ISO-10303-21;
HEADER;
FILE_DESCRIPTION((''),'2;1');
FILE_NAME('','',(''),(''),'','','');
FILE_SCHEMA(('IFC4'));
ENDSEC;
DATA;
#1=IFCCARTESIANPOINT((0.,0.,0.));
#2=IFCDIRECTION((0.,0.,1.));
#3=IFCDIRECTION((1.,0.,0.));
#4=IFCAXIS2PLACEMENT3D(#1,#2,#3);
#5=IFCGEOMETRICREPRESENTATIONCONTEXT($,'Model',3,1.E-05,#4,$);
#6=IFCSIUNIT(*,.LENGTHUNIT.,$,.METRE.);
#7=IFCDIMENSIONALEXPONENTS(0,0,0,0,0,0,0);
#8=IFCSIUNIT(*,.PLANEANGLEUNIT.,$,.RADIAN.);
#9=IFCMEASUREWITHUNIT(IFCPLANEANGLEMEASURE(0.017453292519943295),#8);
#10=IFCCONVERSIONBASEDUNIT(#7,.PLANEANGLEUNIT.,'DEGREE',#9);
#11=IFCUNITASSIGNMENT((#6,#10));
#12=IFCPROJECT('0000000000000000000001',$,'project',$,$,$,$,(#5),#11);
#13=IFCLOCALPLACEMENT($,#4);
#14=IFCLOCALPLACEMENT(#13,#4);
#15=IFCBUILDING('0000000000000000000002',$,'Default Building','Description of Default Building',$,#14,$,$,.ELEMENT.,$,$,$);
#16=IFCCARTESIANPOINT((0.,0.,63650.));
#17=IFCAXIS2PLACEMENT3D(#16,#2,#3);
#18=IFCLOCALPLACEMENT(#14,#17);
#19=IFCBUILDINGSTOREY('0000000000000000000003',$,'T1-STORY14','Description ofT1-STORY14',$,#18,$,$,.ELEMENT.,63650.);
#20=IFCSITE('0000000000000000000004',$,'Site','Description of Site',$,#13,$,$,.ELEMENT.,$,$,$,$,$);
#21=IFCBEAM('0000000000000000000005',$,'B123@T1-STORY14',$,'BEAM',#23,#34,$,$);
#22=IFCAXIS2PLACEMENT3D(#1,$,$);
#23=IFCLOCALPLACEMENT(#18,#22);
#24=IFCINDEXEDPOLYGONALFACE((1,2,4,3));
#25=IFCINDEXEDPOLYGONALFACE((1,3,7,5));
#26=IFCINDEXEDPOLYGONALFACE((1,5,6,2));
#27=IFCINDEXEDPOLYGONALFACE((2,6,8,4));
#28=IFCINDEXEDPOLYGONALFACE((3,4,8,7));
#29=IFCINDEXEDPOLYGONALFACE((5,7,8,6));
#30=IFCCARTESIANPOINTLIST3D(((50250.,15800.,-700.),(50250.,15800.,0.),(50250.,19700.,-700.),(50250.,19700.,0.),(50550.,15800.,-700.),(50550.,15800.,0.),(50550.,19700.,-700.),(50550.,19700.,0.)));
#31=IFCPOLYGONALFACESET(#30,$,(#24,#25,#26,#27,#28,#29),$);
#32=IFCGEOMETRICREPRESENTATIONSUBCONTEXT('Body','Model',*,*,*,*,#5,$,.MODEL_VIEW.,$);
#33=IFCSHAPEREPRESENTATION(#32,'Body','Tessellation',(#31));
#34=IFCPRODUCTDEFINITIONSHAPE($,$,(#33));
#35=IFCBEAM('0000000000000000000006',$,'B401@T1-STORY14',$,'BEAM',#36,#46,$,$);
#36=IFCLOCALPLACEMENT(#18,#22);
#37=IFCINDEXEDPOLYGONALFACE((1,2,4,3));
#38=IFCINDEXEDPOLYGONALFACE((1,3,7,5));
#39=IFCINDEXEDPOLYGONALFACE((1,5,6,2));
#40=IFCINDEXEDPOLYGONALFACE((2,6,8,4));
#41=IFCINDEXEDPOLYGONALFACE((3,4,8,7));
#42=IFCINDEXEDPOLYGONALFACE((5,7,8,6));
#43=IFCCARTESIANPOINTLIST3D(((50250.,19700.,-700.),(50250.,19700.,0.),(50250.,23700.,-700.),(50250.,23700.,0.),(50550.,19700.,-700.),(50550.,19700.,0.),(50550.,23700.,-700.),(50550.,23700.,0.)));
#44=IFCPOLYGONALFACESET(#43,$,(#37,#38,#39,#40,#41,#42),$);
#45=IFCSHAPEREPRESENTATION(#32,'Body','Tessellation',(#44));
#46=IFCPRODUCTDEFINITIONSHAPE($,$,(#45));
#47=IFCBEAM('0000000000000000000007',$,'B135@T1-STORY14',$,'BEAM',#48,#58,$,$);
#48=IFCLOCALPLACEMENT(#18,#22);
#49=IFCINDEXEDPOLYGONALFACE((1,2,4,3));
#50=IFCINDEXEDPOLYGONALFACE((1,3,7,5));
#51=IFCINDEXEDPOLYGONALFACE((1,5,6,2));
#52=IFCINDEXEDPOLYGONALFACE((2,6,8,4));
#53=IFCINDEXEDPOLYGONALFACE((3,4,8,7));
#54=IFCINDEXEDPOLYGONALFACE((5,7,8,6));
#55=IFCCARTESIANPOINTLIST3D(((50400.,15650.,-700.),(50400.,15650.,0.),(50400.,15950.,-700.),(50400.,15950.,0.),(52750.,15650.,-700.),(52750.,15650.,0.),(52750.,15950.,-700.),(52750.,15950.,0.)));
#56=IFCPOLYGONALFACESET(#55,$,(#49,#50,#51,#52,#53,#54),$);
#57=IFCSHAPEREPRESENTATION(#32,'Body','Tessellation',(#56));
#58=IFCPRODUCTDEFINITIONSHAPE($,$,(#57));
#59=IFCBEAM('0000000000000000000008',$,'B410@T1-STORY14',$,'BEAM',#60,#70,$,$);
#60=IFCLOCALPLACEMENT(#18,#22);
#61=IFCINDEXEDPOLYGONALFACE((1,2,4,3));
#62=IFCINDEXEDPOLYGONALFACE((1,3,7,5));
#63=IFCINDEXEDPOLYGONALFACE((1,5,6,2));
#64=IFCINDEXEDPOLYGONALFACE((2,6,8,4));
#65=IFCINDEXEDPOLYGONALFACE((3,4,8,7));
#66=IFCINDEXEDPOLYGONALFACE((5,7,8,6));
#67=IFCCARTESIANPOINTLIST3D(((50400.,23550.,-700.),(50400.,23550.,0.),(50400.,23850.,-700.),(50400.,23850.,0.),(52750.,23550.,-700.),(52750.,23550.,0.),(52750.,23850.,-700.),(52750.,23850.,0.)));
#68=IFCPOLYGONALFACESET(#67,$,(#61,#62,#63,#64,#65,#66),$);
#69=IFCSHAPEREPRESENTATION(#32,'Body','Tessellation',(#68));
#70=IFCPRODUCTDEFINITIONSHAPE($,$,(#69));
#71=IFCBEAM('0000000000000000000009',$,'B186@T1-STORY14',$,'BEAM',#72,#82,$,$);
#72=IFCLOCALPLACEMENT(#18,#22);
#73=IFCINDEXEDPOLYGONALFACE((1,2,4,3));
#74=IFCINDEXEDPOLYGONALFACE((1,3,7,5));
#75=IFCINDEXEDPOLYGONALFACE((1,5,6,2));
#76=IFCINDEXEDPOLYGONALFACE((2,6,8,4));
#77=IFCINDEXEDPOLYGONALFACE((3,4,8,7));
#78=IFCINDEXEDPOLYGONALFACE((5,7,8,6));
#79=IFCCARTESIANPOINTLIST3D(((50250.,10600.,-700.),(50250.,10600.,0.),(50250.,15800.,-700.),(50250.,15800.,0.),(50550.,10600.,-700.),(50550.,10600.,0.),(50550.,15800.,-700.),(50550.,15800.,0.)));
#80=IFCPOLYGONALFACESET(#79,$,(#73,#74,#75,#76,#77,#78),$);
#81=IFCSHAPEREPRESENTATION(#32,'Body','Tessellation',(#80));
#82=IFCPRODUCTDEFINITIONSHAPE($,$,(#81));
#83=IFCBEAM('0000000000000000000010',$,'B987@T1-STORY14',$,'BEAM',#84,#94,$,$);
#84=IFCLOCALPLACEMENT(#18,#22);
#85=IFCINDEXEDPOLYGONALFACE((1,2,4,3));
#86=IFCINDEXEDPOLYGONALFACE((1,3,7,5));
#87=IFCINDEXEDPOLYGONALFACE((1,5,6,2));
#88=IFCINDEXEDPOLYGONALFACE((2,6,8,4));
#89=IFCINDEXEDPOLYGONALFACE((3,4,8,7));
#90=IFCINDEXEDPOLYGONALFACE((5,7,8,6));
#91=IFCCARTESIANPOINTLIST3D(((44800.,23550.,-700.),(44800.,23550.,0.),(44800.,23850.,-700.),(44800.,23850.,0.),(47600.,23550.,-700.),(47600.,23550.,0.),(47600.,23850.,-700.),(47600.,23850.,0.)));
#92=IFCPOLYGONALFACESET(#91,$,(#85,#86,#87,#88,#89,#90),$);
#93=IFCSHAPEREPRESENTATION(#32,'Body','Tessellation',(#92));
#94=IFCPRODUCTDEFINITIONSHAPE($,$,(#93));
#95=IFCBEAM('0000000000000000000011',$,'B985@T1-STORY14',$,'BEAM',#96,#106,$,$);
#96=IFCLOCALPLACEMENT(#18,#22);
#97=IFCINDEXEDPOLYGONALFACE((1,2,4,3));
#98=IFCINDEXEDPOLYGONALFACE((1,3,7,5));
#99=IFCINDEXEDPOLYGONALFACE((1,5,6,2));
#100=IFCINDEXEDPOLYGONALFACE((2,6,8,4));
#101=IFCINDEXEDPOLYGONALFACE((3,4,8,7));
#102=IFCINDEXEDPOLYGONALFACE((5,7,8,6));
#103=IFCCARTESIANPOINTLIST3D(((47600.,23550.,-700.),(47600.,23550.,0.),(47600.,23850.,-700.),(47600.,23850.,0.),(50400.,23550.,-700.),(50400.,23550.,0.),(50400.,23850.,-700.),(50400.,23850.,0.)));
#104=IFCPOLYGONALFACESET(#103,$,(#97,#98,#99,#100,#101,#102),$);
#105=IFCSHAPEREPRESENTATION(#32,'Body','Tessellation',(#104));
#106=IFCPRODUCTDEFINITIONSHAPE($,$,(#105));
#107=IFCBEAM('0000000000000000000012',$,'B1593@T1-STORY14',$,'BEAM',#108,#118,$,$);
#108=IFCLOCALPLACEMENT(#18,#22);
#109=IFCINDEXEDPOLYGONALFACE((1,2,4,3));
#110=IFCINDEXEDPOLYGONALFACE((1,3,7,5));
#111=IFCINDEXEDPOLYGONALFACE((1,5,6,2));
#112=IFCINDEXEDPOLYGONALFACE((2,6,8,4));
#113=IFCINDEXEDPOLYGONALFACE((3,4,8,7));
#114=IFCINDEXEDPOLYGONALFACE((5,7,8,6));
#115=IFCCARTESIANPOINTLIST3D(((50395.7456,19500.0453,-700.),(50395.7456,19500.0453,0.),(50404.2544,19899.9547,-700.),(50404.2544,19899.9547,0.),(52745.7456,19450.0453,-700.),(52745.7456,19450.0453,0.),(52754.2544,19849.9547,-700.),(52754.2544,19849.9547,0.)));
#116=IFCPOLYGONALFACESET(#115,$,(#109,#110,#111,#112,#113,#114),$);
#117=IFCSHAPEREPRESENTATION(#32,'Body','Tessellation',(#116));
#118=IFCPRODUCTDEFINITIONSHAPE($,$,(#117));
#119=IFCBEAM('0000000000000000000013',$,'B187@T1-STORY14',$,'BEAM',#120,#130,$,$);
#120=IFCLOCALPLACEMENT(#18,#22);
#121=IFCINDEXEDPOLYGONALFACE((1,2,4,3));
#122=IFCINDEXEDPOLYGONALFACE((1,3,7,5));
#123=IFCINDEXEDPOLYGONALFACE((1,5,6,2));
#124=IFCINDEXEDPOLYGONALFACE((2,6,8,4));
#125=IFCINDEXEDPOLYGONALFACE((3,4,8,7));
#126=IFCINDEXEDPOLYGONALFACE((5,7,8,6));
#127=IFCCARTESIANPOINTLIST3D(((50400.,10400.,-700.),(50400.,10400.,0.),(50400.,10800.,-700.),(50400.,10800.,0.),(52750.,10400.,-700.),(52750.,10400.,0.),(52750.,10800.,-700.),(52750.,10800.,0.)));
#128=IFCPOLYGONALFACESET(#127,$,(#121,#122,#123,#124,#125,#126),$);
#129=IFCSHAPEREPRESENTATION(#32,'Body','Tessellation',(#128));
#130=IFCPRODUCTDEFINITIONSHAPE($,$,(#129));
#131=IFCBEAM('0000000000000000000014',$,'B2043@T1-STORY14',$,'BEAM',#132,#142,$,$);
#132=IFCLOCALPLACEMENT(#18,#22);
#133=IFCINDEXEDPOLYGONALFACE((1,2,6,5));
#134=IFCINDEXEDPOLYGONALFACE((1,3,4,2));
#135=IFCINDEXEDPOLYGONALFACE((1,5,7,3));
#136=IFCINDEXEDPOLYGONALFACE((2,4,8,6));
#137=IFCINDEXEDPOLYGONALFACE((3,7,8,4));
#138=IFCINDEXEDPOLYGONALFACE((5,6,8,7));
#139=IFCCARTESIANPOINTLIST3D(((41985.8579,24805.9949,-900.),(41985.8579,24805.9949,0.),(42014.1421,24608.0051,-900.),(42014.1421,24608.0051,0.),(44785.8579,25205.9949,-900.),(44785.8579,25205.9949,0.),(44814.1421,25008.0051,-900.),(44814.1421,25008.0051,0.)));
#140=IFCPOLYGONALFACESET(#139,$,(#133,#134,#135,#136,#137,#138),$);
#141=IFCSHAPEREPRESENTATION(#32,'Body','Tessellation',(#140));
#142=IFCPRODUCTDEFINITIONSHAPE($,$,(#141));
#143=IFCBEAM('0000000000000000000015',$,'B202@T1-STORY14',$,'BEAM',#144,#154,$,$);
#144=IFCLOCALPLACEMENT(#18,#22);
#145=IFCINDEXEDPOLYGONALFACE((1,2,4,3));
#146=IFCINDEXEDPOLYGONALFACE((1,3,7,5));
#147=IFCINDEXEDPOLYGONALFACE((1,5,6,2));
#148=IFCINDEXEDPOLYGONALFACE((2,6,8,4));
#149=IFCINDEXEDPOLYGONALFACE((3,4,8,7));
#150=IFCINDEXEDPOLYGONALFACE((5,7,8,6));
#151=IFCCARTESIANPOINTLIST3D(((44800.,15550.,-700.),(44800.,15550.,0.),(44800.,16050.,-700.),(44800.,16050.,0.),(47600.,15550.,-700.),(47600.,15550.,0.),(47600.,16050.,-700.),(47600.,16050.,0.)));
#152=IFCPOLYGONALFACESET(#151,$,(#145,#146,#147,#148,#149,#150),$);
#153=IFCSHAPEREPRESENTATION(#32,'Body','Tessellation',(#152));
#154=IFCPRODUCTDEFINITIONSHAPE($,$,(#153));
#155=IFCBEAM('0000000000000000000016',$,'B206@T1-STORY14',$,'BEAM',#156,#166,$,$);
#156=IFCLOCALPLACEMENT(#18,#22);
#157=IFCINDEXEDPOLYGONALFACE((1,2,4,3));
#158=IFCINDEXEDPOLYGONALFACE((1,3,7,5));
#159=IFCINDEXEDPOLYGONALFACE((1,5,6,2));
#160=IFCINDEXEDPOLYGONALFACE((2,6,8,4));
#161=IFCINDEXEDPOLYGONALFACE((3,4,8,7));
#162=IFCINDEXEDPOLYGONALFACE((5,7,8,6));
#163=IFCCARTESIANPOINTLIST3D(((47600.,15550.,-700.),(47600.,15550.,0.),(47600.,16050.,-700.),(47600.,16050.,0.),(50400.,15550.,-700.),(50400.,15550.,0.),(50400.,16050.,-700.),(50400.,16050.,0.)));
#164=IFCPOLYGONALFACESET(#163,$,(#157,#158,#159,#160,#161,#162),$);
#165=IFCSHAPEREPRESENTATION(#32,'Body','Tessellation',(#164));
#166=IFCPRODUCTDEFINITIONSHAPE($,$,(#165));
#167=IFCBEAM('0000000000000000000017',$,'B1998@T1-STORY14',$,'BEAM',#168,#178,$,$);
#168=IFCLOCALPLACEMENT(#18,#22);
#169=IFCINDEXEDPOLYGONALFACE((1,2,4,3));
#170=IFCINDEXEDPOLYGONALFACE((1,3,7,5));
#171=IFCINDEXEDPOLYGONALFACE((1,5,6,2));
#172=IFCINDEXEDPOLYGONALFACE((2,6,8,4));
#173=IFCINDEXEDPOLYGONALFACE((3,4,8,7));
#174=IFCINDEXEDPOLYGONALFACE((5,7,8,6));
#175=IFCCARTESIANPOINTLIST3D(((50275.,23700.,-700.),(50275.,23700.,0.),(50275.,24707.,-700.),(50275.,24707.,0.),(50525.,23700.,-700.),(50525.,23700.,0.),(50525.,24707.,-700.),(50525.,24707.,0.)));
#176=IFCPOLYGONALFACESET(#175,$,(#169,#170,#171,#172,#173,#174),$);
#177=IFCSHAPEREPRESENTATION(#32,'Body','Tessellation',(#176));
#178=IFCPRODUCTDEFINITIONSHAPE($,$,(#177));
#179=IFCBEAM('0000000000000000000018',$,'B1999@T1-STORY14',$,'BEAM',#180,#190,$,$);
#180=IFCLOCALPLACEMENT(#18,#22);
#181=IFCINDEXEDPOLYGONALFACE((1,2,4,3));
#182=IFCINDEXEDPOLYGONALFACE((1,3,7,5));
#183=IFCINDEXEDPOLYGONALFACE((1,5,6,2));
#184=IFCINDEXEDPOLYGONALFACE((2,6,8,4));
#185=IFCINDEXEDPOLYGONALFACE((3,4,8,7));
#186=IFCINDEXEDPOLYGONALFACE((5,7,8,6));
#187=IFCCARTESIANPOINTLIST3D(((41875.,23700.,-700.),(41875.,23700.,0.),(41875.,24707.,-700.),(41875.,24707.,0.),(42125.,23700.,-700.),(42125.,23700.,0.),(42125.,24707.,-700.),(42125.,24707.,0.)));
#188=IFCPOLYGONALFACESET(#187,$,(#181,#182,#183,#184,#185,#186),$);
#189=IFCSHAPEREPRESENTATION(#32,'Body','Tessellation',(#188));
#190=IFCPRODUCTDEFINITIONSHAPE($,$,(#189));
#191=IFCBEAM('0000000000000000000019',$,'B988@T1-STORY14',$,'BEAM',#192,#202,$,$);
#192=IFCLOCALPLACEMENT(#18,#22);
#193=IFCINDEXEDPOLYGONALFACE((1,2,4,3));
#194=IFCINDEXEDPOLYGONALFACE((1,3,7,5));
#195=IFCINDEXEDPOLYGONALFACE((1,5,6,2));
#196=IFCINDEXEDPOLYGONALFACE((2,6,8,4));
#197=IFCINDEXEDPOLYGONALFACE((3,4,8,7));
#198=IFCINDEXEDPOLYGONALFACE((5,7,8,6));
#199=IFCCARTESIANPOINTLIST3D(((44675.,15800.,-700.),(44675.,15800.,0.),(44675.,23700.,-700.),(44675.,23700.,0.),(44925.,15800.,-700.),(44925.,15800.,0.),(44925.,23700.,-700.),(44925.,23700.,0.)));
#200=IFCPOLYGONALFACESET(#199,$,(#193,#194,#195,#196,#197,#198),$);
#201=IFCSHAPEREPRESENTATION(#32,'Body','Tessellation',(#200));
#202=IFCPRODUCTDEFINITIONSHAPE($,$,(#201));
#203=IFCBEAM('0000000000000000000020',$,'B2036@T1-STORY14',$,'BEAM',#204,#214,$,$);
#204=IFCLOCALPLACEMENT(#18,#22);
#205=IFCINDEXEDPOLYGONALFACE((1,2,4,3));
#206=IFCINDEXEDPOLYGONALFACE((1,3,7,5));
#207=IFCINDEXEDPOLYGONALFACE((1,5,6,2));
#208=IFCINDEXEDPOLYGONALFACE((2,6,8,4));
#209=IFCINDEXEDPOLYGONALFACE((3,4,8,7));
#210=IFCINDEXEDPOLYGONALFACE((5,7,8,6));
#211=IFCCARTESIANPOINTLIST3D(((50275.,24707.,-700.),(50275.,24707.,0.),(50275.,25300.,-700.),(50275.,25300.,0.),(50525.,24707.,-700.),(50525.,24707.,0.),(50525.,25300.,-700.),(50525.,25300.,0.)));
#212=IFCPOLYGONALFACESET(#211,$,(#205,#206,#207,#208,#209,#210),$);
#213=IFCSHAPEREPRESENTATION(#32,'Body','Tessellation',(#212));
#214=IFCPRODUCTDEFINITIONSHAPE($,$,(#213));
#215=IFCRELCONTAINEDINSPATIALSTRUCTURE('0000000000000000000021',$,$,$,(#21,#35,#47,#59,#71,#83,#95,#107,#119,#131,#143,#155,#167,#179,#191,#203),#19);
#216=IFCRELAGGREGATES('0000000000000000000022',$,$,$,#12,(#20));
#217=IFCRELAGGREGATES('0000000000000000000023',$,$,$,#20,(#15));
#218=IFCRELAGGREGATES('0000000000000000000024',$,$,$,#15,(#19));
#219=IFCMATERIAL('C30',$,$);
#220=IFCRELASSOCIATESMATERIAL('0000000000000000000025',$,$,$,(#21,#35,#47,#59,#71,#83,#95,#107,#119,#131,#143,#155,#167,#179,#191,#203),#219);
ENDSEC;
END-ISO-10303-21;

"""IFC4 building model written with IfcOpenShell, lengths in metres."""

from ifc_helpers import new_model, entity, si_unit, converted_unit, frame, origin_with_axes, place, context, subcontext, project, spatial, rectangle, extrude, material, element, save


model = new_model("IFC4")

# Units and contexts
model_context = context("Model", 3, precision=1e-05, world=origin_with_axes())
body_context = subcontext(model_context, "Body", "Model", "MODEL_VIEW")
ifc_project = project(units=[si_unit("LENGTHUNIT", "METRE"), converted_unit("PLANEANGLEUNIT", "DEGREE", entity("IfcPlaneAngleMeasure", 0.017453292519943295), si_unit("PLANEANGLEUNIT", "RADIAN"), dimensions=[0, 0, 0, 0, 0, 0, 0])], contexts=[model_context])

# Site, building, storey
site_placement = place(None, origin_with_axes())
site = spatial("IfcSite", under=ifc_project, at=site_placement, Name="Site", Description="Description of Site", CompositionType="ELEMENT")
building_placement = place(site_placement, origin_with_axes())
building = spatial("IfcBuilding", under=site, at=building_placement, Name="Default Building", Description="Description of Default Building", CompositionType="ELEMENT")
storey_placement = place(building_placement, frame((0.0, 0.0, 63650.0), z_axis=(0.0, 0.0, 1.0), x_axis=(1.0, 0.0, 0.0)))
storey = spatial("IfcBuildingStorey", under=building, at=storey_placement, Name="T1-STORY14", Description="Description ofT1-STORY14", CompositionType="ELEMENT", Elevation=63650.0)

# Beams
ifc_material_1 = material(Name="C30")
beam_1_placement = place(storey_placement, frame((50400.0, 15800.0, -350.0), z_axis=(0.0, 1.0, 0.0), x_axis=(-1.0, 0.0, 0.0)))
element("IfcBeam", 1, at=beam_1_placement, inside=storey, material=ifc_material_1, Name="B123@T1-STORY14", ObjectType="BEAM", context=body_context, shape_type="SweptSolid", body=[
    extrude(rectangle(XDim=300.0, YDim=700.0), origin_with_axes(), (0.0, 0.0, 1.0), 3900.0),
])
beam_2_placement = place(storey_placement, frame((50400.0, 19700.0, -350.0), z_axis=(0.0, 1.0, 0.0), x_axis=(-1.0, 0.0, 0.0)))
element("IfcBeam", 2, at=beam_2_placement, inside=storey, material=ifc_material_1, Name="B401@T1-STORY14", ObjectType="BEAM", context=body_context, shape_type="SweptSolid", body=[
    extrude(rectangle(XDim=300.0, YDim=700.0), origin_with_axes(), (0.0, 0.0, 1.0), 4000.0),
])
for number, where, z_axis, x_axis, name in (
    (3, (50400.0, 15800.0, -350.0), (1.0, 0.0, 0.0), (0.0, 1.0, 0.0), "B135@T1-STORY14"),
    (4, (50400.0, 23700.0, -350.0), (1.0, 0.0, 0.0), (0.0, 1.0, 0.0), "B410@T1-STORY14"),
):
    element("IfcBeam", number, at=place(storey_placement, frame(where, z_axis=z_axis, x_axis=x_axis)), inside=storey, material=ifc_material_1, Name=name, ObjectType="BEAM", context=body_context, shape_type="SweptSolid", body=[
        extrude(rectangle(XDim=300.0, YDim=700.0), origin_with_axes(), (0.0, 0.0, 1.0), 2350.0),
    ])
beam_3_placement = place(storey_placement, frame((50400.0, 10600.0, -350.0), z_axis=(0.0, 1.0, 0.0), x_axis=(-1.0, 0.0, 0.0)))
element("IfcBeam", 5, at=beam_3_placement, inside=storey, material=ifc_material_1, Name="B186@T1-STORY14", ObjectType="BEAM", context=body_context, shape_type="SweptSolid", body=[
    extrude(rectangle(XDim=300.0, YDim=700.0), origin_with_axes(), (0.0, 0.0, 1.0), 5200.0),
])
for number, where, z_axis, x_axis, name in (
    (6, (44800.0, 23700.0, -350.0), (1.0, 0.0, 0.0), (0.0, 1.0, 0.0), "B987@T1-STORY14"),
    (7, (47600.0, 23700.0, -350.0), (1.0, 0.0, 0.0), (0.0, 1.0, 0.0), "B985@T1-STORY14"),
):
    element("IfcBeam", number, at=place(storey_placement, frame(where, z_axis=z_axis, x_axis=x_axis)), inside=storey, material=ifc_material_1, Name=name, ObjectType="BEAM", context=body_context, shape_type="SweptSolid", body=[
        extrude(rectangle(XDim=300.0, YDim=700.0), origin_with_axes(), (0.0, 0.0, 1.0), 2800.0),
    ])
beam_4_placement = place(storey_placement, frame((50400.0, 19700.0, -350.0), z_axis=(0.999774, -0.021272, 0.0), x_axis=(0.021272, 0.999774, 0.0)))
element("IfcBeam", 8, at=beam_4_placement, inside=storey, material=ifc_material_1, Name="B1593@T1-STORY14", ObjectType="BEAM", context=body_context, shape_type="SweptSolid", body=[
    extrude(rectangle(XDim=400.0, YDim=700.0), origin_with_axes(), (0.0, 0.0, 1.0), 2350.5319),
])
beam_5_placement = place(storey_placement, frame((50400.0, 10600.0, -350.0), z_axis=(1.0, 0.0, 0.0), x_axis=(0.0, 1.0, 0.0)))
element("IfcBeam", 9, at=beam_5_placement, inside=storey, material=ifc_material_1, Name="B187@T1-STORY14", ObjectType="BEAM", context=body_context, shape_type="SweptSolid", body=[
    extrude(rectangle(XDim=400.0, YDim=700.0), origin_with_axes(), (0.0, 0.0, 1.0), 2350.0),
])
beam_6_placement = place(storey_placement, frame((42000.0, 24707.0, -450.0), z_axis=(0.989949, 0.141421, 0.0), x_axis=(-0.141421, 0.989949, 0.0)))
element("IfcBeam", 10, at=beam_6_placement, inside=storey, material=ifc_material_1, Name="B2043@T1-STORY14", ObjectType="BEAM", context=body_context, shape_type="SweptSolid", body=[
    extrude(rectangle(XDim=200.0, YDim=900.0), origin_with_axes(), (0.0, 0.0, 1.0), 2828.4271),
])
for number, where, z_axis, x_axis, name in (
    (11, (44800.0, 15800.0, -350.0), (1.0, 0.0, 0.0), (0.0, 1.0, 0.0), "B202@T1-STORY14"),
    (12, (47600.0, 15800.0, -350.0), (1.0, 0.0, 0.0), (0.0, 1.0, 0.0), "B206@T1-STORY14"),
):
    element("IfcBeam", number, at=place(storey_placement, frame(where, z_axis=z_axis, x_axis=x_axis)), inside=storey, material=ifc_material_1, Name=name, ObjectType="BEAM", context=body_context, shape_type="SweptSolid", body=[
        extrude(rectangle(XDim=500.0, YDim=700.0), origin_with_axes(), (0.0, 0.0, 1.0), 2800.0),
    ])
for number, where, z_axis, x_axis, name in (
    (13, (50400.0, 23700.0, -350.0), (0.0, 1.0, 0.0), (-1.0, 0.0, 0.0), "B1998@T1-STORY14"),
    (14, (42000.0, 23700.0, -350.0), (0.0, 1.0, 0.0), (-1.0, 0.0, 0.0), "B1999@T1-STORY14"),
):
    element("IfcBeam", number, at=place(storey_placement, frame(where, z_axis=z_axis, x_axis=x_axis)), inside=storey, material=ifc_material_1, Name=name, ObjectType="BEAM", context=body_context, shape_type="SweptSolid", body=[
        extrude(rectangle(XDim=250.0, YDim=700.0), origin_with_axes(), (0.0, 0.0, 1.0), 1007.0),
    ])
beam_7_placement = place(storey_placement, frame((44800.0, 15800.0, -350.0), z_axis=(0.0, 1.0, 0.0), x_axis=(-1.0, 0.0, 0.0)))
element("IfcBeam", 15, at=beam_7_placement, inside=storey, material=ifc_material_1, Name="B988@T1-STORY14", ObjectType="BEAM", context=body_context, shape_type="SweptSolid", body=[
    extrude(rectangle(XDim=250.0, YDim=700.0), origin_with_axes(), (0.0, 0.0, 1.0), 7900.0),
])
beam_8_placement = place(storey_placement, frame((50400.0, 24707.0, -350.0), z_axis=(0.0, 1.0, 0.0), x_axis=(-1.0, 0.0, 0.0)))
element("IfcBeam", 16, at=beam_8_placement, inside=storey, material=ifc_material_1, Name="B2036@T1-STORY14", ObjectType="BEAM", context=body_context, shape_type="SweptSolid", body=[
    extrude(rectangle(XDim=250.0, YDim=700.0), origin_with_axes(), (0.0, 0.0, 1.0), 593.0),
])

save(model, "model.ifc")
